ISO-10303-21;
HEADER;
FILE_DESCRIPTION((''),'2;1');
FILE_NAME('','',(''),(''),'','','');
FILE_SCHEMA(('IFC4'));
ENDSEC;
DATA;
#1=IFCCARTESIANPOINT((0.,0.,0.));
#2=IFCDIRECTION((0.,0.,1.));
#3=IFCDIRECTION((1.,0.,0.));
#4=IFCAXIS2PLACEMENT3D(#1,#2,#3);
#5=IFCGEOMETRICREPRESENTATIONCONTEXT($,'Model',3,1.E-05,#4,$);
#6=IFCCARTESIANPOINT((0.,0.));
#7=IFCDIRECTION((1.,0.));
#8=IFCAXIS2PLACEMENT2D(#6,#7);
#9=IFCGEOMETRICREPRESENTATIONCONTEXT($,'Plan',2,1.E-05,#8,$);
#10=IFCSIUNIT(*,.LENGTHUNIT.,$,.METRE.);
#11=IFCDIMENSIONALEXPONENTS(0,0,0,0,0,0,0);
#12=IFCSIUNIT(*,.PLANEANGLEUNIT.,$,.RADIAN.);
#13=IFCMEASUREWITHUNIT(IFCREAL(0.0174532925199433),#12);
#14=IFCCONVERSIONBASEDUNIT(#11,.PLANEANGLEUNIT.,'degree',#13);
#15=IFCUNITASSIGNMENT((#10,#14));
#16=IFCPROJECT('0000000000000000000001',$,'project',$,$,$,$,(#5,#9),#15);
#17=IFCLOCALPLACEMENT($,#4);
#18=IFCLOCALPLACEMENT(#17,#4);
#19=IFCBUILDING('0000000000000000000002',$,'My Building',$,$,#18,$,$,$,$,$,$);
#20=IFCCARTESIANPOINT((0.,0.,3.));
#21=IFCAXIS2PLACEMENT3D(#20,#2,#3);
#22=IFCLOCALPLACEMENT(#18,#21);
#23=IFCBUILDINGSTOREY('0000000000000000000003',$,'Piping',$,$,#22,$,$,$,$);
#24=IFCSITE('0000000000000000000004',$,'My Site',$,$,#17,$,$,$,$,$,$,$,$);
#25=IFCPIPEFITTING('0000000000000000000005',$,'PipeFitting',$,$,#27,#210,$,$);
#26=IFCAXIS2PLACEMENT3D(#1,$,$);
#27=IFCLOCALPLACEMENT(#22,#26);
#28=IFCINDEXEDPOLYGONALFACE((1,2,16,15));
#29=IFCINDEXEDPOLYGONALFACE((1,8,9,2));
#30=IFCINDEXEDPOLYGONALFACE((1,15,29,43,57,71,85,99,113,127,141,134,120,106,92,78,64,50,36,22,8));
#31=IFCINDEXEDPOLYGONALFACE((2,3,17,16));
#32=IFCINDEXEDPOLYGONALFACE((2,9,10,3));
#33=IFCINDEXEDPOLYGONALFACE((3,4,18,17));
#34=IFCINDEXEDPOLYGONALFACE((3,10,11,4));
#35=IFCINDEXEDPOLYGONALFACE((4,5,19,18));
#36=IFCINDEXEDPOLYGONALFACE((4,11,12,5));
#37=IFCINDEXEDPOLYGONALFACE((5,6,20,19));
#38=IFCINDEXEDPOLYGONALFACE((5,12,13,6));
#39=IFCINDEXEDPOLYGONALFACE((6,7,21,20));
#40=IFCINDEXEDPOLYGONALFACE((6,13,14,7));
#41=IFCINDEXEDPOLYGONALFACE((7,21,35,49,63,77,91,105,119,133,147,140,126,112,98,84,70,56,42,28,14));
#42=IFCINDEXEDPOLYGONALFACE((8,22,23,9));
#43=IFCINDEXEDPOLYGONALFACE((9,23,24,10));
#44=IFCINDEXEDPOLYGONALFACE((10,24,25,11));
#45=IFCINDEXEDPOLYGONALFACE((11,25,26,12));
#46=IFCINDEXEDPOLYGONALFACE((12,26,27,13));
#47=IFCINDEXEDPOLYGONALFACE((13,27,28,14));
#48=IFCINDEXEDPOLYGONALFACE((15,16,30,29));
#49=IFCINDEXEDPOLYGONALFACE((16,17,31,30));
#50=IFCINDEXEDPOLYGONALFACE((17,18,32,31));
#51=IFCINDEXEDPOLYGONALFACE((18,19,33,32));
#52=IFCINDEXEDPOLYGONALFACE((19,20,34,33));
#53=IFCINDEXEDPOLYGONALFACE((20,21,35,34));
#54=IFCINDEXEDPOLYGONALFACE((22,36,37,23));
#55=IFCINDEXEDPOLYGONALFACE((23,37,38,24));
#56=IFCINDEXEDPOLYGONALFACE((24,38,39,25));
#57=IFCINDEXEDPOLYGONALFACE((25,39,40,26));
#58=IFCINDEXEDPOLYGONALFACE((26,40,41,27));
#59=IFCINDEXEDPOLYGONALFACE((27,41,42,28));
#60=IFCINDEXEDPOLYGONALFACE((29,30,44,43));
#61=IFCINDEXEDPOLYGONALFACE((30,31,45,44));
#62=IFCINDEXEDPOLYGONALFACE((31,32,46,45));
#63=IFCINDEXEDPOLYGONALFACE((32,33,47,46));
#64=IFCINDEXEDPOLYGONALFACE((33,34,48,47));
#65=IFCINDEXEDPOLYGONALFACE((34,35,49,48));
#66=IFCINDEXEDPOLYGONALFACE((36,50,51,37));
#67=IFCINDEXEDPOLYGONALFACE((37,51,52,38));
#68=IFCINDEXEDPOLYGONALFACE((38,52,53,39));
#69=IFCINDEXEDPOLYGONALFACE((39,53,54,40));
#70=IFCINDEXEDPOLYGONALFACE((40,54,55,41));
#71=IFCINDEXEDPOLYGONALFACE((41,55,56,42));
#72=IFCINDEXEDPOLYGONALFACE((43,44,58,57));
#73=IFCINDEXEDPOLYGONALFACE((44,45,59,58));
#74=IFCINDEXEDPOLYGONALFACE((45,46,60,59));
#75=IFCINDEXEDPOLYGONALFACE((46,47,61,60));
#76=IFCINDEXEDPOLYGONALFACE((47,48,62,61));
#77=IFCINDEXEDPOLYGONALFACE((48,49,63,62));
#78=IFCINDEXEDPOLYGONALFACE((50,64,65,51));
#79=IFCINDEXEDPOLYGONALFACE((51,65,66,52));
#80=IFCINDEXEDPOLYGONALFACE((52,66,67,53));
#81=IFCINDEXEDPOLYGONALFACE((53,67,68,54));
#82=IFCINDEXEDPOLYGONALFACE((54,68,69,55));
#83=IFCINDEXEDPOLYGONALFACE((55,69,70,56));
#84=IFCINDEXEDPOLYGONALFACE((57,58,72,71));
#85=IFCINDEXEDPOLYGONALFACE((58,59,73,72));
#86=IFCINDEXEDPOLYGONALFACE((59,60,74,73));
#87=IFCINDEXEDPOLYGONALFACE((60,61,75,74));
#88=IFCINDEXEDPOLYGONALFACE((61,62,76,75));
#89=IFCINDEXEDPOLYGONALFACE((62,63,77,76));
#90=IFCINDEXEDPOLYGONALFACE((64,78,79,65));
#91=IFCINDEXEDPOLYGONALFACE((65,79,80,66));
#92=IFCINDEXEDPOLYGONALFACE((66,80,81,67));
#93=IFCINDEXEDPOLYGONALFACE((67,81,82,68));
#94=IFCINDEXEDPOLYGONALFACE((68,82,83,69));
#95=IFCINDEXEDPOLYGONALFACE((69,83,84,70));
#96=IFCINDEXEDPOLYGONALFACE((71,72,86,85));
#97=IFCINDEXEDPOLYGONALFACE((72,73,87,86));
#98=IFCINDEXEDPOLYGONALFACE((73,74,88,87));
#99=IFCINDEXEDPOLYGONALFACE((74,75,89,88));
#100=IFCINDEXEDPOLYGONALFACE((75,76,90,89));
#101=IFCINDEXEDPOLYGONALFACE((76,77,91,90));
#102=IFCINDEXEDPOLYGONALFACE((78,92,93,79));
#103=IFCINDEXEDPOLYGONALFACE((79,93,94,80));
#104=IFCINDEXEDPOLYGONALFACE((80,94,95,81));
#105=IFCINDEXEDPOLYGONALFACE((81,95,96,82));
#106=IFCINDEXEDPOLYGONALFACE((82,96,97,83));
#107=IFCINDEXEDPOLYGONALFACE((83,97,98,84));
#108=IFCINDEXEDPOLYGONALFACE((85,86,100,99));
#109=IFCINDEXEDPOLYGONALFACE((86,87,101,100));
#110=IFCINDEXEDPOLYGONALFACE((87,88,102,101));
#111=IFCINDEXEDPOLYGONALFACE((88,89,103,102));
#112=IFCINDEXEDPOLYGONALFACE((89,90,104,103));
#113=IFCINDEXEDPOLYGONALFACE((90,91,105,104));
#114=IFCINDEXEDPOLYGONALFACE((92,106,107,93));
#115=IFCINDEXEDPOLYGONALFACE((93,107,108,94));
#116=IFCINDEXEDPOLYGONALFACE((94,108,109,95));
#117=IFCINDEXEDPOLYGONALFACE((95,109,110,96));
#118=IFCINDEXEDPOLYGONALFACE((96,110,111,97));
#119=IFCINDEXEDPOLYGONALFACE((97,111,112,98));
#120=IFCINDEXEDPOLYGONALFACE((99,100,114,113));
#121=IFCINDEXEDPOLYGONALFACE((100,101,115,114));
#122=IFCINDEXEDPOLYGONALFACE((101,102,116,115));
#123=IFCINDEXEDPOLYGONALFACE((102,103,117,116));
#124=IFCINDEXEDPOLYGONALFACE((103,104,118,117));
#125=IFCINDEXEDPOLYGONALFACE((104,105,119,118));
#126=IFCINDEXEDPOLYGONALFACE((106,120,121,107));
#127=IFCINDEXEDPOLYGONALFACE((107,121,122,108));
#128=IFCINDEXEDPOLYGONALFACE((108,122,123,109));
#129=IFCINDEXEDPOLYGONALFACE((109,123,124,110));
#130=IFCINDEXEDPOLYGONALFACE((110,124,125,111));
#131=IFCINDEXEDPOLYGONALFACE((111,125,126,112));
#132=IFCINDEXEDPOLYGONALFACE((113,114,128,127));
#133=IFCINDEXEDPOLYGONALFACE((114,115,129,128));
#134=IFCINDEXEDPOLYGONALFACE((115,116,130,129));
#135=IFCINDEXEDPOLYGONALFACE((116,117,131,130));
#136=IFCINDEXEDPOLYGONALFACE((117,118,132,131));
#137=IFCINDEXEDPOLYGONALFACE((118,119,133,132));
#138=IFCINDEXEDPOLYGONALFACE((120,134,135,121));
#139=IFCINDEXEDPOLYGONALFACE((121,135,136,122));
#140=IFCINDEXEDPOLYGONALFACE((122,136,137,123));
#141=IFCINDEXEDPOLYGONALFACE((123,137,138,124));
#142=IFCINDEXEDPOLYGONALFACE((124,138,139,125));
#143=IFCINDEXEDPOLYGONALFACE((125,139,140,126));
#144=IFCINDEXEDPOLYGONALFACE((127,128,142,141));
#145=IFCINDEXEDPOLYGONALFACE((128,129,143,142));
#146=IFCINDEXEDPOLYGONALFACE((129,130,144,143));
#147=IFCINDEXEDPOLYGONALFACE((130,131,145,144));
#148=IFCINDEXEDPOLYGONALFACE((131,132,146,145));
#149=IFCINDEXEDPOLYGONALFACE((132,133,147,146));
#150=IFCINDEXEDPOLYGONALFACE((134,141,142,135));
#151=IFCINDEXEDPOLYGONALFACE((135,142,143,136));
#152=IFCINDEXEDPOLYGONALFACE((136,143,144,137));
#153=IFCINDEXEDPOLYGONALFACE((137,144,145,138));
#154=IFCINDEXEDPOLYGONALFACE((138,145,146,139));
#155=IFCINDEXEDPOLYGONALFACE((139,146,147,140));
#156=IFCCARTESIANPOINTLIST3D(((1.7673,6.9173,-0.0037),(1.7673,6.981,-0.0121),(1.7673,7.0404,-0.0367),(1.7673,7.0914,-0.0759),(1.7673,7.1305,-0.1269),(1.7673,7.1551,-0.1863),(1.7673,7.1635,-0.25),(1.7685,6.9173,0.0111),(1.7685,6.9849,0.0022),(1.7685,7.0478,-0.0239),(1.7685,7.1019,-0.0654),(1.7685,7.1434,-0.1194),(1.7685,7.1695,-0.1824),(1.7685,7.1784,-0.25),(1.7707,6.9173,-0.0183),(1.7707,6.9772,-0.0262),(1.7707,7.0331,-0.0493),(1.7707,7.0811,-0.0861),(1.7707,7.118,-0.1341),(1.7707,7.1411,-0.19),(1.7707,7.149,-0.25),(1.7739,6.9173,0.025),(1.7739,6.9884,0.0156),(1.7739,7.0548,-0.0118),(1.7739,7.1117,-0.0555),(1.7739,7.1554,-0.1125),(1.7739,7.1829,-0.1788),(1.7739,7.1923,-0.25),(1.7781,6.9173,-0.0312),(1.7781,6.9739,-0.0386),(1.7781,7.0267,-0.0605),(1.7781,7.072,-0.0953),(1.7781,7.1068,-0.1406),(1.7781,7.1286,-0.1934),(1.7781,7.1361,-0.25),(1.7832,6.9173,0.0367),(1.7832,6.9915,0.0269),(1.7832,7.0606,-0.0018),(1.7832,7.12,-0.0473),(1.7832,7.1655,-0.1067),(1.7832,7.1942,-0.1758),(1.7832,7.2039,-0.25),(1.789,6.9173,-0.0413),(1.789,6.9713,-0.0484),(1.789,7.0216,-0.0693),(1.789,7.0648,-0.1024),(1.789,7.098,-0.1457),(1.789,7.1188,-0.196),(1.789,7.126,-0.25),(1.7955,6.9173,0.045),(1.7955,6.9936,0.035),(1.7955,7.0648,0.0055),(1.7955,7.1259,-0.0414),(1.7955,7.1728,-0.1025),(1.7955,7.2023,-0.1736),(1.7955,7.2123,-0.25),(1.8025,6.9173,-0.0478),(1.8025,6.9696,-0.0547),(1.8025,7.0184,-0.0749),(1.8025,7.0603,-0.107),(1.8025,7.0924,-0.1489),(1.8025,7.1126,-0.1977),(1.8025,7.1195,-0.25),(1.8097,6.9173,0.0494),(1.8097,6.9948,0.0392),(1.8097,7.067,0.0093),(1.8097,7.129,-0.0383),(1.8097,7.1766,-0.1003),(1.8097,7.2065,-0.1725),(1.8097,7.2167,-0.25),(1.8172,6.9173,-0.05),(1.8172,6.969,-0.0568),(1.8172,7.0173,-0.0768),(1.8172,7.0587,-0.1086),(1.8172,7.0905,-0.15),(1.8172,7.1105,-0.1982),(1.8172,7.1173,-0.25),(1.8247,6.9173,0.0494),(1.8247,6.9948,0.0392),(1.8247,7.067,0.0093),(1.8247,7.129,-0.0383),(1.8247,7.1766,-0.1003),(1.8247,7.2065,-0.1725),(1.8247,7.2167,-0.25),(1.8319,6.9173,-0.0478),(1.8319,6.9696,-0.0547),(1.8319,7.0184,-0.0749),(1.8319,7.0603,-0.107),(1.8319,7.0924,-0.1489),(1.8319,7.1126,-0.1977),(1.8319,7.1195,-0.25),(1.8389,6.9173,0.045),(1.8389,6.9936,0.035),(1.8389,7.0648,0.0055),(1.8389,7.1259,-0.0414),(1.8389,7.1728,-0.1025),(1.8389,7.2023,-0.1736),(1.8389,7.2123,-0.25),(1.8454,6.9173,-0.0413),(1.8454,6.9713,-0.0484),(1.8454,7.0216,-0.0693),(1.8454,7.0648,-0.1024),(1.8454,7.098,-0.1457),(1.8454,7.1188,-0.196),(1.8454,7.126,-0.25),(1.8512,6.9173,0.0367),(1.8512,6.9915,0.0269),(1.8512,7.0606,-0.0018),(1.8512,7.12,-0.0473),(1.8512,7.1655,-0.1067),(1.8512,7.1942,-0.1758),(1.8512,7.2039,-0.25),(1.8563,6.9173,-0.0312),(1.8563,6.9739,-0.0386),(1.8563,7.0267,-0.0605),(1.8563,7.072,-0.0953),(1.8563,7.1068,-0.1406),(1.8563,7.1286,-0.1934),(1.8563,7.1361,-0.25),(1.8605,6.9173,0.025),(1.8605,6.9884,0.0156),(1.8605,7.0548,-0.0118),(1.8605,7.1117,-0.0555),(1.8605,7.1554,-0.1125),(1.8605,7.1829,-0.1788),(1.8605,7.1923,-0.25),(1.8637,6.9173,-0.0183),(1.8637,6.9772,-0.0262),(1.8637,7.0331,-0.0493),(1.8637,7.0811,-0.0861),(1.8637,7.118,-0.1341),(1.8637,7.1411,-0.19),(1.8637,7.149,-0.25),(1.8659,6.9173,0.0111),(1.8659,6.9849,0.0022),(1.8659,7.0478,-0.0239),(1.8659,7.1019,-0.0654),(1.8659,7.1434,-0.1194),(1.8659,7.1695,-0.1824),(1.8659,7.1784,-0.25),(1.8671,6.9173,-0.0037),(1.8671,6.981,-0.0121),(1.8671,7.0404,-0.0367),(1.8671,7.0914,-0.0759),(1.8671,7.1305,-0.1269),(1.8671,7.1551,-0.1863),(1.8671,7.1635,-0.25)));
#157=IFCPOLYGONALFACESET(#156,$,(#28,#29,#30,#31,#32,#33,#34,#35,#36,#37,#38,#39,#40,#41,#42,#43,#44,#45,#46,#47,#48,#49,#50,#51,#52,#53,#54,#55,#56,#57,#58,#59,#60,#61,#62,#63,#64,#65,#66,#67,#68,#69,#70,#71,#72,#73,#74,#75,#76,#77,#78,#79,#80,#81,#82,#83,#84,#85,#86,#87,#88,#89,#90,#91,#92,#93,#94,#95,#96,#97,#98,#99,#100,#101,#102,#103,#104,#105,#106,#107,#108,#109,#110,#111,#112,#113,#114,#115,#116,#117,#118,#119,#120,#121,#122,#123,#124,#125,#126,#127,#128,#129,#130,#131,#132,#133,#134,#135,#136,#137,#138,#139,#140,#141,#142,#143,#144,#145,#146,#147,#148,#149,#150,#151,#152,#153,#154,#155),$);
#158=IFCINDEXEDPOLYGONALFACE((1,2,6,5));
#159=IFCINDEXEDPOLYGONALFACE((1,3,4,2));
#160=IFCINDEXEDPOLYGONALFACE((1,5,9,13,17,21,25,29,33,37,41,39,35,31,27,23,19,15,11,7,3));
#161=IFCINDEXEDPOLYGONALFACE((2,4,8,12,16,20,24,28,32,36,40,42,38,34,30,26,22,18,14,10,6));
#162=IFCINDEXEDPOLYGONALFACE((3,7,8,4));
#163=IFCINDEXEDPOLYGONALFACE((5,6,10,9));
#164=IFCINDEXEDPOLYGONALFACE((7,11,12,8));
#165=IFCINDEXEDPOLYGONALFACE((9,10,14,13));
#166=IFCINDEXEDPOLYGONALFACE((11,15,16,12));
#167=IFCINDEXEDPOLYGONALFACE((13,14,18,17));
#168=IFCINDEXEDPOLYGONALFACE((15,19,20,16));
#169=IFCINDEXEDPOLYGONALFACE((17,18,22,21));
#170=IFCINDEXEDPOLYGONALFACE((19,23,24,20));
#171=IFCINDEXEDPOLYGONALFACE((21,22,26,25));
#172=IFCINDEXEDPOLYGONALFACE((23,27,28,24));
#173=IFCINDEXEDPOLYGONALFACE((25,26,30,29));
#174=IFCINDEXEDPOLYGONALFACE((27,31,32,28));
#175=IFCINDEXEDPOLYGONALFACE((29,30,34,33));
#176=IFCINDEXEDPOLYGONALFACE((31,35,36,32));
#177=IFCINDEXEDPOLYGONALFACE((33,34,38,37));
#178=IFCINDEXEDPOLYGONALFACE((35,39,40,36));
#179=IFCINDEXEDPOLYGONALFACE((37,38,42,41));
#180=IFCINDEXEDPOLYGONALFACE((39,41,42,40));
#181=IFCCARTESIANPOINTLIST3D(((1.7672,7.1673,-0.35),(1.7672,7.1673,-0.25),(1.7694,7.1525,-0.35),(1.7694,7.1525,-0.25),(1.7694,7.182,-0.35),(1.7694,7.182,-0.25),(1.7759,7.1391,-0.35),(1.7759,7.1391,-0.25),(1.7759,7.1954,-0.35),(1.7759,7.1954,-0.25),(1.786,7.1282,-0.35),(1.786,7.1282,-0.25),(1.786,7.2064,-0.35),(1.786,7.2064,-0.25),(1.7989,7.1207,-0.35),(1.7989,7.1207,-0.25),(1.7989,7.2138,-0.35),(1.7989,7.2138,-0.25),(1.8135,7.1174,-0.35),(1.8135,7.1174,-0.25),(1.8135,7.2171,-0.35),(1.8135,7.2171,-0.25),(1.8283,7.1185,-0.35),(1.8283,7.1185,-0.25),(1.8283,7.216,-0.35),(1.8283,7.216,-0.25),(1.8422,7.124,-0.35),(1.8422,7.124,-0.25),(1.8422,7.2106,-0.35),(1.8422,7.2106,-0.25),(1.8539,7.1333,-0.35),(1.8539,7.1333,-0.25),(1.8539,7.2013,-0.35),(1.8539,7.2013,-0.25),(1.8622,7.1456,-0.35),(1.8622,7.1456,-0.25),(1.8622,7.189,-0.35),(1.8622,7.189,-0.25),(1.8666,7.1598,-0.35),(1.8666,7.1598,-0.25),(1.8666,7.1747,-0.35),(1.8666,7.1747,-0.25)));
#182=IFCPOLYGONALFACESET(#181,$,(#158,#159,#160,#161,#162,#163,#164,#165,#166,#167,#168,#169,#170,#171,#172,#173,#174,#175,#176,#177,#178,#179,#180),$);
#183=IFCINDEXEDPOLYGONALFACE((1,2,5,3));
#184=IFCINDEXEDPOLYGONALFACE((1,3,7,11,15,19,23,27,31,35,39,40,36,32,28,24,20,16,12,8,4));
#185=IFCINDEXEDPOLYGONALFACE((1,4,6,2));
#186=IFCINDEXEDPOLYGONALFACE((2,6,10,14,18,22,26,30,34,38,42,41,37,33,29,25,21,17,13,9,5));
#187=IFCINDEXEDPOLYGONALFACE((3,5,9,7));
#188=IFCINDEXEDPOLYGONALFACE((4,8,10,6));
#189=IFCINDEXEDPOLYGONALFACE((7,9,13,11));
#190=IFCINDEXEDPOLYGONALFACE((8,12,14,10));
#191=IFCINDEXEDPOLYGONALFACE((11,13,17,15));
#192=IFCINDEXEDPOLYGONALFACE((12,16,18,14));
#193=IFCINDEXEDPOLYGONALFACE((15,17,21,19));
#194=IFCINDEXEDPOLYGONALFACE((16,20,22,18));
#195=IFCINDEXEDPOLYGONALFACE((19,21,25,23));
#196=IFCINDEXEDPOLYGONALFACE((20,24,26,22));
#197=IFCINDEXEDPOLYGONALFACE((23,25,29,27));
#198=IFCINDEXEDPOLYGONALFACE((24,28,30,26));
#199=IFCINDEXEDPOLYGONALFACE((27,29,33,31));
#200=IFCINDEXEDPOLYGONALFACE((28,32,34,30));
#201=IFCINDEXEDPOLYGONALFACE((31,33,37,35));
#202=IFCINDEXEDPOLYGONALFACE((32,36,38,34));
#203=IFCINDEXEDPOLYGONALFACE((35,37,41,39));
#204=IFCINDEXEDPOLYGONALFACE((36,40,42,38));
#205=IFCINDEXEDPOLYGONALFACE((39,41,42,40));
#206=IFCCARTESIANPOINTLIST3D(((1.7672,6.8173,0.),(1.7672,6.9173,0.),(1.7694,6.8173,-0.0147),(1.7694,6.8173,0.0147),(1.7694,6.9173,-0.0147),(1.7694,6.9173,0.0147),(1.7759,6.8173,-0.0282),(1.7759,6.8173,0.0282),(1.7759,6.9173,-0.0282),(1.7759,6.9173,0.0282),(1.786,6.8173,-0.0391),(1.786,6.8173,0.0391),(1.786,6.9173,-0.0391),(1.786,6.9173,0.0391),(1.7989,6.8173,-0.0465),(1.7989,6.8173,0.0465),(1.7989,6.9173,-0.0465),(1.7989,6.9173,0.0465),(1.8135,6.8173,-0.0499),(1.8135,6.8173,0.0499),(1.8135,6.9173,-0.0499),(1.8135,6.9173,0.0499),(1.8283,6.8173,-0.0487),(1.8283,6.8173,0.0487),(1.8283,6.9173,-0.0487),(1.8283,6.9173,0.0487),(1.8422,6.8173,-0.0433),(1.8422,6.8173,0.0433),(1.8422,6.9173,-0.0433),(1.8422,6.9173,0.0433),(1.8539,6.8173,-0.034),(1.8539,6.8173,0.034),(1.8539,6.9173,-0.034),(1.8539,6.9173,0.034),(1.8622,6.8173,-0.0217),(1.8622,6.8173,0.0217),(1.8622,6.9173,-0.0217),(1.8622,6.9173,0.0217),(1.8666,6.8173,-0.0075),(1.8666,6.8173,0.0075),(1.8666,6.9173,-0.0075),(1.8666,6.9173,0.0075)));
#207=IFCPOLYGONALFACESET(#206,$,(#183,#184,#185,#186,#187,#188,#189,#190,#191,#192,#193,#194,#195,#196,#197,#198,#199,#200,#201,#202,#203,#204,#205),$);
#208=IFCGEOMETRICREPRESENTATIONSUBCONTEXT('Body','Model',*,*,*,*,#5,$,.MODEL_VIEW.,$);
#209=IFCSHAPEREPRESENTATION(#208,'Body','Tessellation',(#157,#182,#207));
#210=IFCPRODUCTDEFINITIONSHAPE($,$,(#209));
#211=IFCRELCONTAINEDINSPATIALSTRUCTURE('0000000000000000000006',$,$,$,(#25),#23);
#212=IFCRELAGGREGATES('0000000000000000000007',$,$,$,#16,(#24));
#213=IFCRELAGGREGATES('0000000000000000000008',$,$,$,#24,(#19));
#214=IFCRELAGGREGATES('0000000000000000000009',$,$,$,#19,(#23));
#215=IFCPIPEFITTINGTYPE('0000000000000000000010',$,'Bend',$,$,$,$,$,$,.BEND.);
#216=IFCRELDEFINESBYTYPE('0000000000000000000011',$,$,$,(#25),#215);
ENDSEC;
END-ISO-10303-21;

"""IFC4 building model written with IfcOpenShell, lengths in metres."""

from ifc_helpers import new_model, entity, si_unit, converted_unit, frame, origin_with_axes, origin_2d_with_axis, place, context, subcontext, project, spatial, circle, extrude, source, transform, mapped, type_object, type_shapes, element, save


model = new_model("IFC4")

# Units and contexts
model_context = context("Model", 3, precision=1e-05, world=origin_with_axes())
plan_context = context("Plan", 2, precision=1e-05, world=origin_2d_with_axis())
body_context = subcontext(model_context, "Body", "Model", "MODEL_VIEW")
ifc_project = project(units=[si_unit("LENGTHUNIT", "METRE"), converted_unit("PLANEANGLEUNIT", "degree", entity("IfcReal", 0.0174532925199433), si_unit("PLANEANGLEUNIT", "RADIAN"), dimensions=[0, 0, 0, 0, 0, 0, 0])], contexts=[model_context, plan_context])

# Site, building, storey
site_placement = place(None, origin_with_axes())
site = spatial("IfcSite", under=ifc_project, at=site_placement, Name="My Site")
building_placement = place(site_placement, origin_with_axes())
building = spatial("IfcBuilding", under=site, at=building_placement, Name="My Building")
storey_placement = place(building_placement, frame((0.0, 0.0, 3.0), z_axis=(0.0, 0.0, 1.0), x_axis=(1.0, 0.0, 0.0)))
storey = spatial("IfcBuildingStorey", under=building, at=storey_placement, Name="Piping")

# Pipe fitting
pipe_fitting_type = type_object("IfcPipeFittingType", Name="Bend", PredefinedType="BEND")
shared_shape = source(origin_with_axes(), body_context, "Body", "SolidModel", [
    entity("IfcSweptDiskSolid", entity("IfcIndexedPolyCurve", entity("IfcCartesianPointList3D", [[0.0, 0.0, -0.1], [0.0, -0.0732, -0.2768], [0.0, -0.25, -0.35]]), [entity("IfcArcIndex", [1, 2, 3])]), 0.05),
    extrude(circle(Radius=0.05), origin_with_axes(), (0.0, 0.0, -1.0), 0.1),
    extrude(circle(Radius=0.05), frame((0.0, -0.25, -0.35), z_axis=(0.0, -1.0, 0.0), x_axis=(1.0, 0.0, 0.0)), (0.0, 0.0, 1.0), 0.1),
])
type_shapes(pipe_fitting_type, [shared_shape])
for number, where, z_axis, x_axis, name in (
    (1, (1.8172, 7.1673, -0.35), (0.0, 0.0, -1.0), (-1.0, 0.0, 0.0), "PipeFitting"),
):
    element("IfcPipeFitting", number, at=place(storey_placement, frame(where, z_axis=z_axis, x_axis=x_axis)), inside=storey, type_object=pipe_fitting_type, Name=name, context=body_context, shape_type="MappedRepresentation", body=[
        mapped(shared_shape, transform((0.0, 0.0, 0.0), x_axis=(1.0, 0.0, 0.0), y_axis=(0.0, 1.0, 0.0), z_axis=(0.0, 0.0, 1.0), scale=1.0)),
    ])

save(model, "model.ifc")
